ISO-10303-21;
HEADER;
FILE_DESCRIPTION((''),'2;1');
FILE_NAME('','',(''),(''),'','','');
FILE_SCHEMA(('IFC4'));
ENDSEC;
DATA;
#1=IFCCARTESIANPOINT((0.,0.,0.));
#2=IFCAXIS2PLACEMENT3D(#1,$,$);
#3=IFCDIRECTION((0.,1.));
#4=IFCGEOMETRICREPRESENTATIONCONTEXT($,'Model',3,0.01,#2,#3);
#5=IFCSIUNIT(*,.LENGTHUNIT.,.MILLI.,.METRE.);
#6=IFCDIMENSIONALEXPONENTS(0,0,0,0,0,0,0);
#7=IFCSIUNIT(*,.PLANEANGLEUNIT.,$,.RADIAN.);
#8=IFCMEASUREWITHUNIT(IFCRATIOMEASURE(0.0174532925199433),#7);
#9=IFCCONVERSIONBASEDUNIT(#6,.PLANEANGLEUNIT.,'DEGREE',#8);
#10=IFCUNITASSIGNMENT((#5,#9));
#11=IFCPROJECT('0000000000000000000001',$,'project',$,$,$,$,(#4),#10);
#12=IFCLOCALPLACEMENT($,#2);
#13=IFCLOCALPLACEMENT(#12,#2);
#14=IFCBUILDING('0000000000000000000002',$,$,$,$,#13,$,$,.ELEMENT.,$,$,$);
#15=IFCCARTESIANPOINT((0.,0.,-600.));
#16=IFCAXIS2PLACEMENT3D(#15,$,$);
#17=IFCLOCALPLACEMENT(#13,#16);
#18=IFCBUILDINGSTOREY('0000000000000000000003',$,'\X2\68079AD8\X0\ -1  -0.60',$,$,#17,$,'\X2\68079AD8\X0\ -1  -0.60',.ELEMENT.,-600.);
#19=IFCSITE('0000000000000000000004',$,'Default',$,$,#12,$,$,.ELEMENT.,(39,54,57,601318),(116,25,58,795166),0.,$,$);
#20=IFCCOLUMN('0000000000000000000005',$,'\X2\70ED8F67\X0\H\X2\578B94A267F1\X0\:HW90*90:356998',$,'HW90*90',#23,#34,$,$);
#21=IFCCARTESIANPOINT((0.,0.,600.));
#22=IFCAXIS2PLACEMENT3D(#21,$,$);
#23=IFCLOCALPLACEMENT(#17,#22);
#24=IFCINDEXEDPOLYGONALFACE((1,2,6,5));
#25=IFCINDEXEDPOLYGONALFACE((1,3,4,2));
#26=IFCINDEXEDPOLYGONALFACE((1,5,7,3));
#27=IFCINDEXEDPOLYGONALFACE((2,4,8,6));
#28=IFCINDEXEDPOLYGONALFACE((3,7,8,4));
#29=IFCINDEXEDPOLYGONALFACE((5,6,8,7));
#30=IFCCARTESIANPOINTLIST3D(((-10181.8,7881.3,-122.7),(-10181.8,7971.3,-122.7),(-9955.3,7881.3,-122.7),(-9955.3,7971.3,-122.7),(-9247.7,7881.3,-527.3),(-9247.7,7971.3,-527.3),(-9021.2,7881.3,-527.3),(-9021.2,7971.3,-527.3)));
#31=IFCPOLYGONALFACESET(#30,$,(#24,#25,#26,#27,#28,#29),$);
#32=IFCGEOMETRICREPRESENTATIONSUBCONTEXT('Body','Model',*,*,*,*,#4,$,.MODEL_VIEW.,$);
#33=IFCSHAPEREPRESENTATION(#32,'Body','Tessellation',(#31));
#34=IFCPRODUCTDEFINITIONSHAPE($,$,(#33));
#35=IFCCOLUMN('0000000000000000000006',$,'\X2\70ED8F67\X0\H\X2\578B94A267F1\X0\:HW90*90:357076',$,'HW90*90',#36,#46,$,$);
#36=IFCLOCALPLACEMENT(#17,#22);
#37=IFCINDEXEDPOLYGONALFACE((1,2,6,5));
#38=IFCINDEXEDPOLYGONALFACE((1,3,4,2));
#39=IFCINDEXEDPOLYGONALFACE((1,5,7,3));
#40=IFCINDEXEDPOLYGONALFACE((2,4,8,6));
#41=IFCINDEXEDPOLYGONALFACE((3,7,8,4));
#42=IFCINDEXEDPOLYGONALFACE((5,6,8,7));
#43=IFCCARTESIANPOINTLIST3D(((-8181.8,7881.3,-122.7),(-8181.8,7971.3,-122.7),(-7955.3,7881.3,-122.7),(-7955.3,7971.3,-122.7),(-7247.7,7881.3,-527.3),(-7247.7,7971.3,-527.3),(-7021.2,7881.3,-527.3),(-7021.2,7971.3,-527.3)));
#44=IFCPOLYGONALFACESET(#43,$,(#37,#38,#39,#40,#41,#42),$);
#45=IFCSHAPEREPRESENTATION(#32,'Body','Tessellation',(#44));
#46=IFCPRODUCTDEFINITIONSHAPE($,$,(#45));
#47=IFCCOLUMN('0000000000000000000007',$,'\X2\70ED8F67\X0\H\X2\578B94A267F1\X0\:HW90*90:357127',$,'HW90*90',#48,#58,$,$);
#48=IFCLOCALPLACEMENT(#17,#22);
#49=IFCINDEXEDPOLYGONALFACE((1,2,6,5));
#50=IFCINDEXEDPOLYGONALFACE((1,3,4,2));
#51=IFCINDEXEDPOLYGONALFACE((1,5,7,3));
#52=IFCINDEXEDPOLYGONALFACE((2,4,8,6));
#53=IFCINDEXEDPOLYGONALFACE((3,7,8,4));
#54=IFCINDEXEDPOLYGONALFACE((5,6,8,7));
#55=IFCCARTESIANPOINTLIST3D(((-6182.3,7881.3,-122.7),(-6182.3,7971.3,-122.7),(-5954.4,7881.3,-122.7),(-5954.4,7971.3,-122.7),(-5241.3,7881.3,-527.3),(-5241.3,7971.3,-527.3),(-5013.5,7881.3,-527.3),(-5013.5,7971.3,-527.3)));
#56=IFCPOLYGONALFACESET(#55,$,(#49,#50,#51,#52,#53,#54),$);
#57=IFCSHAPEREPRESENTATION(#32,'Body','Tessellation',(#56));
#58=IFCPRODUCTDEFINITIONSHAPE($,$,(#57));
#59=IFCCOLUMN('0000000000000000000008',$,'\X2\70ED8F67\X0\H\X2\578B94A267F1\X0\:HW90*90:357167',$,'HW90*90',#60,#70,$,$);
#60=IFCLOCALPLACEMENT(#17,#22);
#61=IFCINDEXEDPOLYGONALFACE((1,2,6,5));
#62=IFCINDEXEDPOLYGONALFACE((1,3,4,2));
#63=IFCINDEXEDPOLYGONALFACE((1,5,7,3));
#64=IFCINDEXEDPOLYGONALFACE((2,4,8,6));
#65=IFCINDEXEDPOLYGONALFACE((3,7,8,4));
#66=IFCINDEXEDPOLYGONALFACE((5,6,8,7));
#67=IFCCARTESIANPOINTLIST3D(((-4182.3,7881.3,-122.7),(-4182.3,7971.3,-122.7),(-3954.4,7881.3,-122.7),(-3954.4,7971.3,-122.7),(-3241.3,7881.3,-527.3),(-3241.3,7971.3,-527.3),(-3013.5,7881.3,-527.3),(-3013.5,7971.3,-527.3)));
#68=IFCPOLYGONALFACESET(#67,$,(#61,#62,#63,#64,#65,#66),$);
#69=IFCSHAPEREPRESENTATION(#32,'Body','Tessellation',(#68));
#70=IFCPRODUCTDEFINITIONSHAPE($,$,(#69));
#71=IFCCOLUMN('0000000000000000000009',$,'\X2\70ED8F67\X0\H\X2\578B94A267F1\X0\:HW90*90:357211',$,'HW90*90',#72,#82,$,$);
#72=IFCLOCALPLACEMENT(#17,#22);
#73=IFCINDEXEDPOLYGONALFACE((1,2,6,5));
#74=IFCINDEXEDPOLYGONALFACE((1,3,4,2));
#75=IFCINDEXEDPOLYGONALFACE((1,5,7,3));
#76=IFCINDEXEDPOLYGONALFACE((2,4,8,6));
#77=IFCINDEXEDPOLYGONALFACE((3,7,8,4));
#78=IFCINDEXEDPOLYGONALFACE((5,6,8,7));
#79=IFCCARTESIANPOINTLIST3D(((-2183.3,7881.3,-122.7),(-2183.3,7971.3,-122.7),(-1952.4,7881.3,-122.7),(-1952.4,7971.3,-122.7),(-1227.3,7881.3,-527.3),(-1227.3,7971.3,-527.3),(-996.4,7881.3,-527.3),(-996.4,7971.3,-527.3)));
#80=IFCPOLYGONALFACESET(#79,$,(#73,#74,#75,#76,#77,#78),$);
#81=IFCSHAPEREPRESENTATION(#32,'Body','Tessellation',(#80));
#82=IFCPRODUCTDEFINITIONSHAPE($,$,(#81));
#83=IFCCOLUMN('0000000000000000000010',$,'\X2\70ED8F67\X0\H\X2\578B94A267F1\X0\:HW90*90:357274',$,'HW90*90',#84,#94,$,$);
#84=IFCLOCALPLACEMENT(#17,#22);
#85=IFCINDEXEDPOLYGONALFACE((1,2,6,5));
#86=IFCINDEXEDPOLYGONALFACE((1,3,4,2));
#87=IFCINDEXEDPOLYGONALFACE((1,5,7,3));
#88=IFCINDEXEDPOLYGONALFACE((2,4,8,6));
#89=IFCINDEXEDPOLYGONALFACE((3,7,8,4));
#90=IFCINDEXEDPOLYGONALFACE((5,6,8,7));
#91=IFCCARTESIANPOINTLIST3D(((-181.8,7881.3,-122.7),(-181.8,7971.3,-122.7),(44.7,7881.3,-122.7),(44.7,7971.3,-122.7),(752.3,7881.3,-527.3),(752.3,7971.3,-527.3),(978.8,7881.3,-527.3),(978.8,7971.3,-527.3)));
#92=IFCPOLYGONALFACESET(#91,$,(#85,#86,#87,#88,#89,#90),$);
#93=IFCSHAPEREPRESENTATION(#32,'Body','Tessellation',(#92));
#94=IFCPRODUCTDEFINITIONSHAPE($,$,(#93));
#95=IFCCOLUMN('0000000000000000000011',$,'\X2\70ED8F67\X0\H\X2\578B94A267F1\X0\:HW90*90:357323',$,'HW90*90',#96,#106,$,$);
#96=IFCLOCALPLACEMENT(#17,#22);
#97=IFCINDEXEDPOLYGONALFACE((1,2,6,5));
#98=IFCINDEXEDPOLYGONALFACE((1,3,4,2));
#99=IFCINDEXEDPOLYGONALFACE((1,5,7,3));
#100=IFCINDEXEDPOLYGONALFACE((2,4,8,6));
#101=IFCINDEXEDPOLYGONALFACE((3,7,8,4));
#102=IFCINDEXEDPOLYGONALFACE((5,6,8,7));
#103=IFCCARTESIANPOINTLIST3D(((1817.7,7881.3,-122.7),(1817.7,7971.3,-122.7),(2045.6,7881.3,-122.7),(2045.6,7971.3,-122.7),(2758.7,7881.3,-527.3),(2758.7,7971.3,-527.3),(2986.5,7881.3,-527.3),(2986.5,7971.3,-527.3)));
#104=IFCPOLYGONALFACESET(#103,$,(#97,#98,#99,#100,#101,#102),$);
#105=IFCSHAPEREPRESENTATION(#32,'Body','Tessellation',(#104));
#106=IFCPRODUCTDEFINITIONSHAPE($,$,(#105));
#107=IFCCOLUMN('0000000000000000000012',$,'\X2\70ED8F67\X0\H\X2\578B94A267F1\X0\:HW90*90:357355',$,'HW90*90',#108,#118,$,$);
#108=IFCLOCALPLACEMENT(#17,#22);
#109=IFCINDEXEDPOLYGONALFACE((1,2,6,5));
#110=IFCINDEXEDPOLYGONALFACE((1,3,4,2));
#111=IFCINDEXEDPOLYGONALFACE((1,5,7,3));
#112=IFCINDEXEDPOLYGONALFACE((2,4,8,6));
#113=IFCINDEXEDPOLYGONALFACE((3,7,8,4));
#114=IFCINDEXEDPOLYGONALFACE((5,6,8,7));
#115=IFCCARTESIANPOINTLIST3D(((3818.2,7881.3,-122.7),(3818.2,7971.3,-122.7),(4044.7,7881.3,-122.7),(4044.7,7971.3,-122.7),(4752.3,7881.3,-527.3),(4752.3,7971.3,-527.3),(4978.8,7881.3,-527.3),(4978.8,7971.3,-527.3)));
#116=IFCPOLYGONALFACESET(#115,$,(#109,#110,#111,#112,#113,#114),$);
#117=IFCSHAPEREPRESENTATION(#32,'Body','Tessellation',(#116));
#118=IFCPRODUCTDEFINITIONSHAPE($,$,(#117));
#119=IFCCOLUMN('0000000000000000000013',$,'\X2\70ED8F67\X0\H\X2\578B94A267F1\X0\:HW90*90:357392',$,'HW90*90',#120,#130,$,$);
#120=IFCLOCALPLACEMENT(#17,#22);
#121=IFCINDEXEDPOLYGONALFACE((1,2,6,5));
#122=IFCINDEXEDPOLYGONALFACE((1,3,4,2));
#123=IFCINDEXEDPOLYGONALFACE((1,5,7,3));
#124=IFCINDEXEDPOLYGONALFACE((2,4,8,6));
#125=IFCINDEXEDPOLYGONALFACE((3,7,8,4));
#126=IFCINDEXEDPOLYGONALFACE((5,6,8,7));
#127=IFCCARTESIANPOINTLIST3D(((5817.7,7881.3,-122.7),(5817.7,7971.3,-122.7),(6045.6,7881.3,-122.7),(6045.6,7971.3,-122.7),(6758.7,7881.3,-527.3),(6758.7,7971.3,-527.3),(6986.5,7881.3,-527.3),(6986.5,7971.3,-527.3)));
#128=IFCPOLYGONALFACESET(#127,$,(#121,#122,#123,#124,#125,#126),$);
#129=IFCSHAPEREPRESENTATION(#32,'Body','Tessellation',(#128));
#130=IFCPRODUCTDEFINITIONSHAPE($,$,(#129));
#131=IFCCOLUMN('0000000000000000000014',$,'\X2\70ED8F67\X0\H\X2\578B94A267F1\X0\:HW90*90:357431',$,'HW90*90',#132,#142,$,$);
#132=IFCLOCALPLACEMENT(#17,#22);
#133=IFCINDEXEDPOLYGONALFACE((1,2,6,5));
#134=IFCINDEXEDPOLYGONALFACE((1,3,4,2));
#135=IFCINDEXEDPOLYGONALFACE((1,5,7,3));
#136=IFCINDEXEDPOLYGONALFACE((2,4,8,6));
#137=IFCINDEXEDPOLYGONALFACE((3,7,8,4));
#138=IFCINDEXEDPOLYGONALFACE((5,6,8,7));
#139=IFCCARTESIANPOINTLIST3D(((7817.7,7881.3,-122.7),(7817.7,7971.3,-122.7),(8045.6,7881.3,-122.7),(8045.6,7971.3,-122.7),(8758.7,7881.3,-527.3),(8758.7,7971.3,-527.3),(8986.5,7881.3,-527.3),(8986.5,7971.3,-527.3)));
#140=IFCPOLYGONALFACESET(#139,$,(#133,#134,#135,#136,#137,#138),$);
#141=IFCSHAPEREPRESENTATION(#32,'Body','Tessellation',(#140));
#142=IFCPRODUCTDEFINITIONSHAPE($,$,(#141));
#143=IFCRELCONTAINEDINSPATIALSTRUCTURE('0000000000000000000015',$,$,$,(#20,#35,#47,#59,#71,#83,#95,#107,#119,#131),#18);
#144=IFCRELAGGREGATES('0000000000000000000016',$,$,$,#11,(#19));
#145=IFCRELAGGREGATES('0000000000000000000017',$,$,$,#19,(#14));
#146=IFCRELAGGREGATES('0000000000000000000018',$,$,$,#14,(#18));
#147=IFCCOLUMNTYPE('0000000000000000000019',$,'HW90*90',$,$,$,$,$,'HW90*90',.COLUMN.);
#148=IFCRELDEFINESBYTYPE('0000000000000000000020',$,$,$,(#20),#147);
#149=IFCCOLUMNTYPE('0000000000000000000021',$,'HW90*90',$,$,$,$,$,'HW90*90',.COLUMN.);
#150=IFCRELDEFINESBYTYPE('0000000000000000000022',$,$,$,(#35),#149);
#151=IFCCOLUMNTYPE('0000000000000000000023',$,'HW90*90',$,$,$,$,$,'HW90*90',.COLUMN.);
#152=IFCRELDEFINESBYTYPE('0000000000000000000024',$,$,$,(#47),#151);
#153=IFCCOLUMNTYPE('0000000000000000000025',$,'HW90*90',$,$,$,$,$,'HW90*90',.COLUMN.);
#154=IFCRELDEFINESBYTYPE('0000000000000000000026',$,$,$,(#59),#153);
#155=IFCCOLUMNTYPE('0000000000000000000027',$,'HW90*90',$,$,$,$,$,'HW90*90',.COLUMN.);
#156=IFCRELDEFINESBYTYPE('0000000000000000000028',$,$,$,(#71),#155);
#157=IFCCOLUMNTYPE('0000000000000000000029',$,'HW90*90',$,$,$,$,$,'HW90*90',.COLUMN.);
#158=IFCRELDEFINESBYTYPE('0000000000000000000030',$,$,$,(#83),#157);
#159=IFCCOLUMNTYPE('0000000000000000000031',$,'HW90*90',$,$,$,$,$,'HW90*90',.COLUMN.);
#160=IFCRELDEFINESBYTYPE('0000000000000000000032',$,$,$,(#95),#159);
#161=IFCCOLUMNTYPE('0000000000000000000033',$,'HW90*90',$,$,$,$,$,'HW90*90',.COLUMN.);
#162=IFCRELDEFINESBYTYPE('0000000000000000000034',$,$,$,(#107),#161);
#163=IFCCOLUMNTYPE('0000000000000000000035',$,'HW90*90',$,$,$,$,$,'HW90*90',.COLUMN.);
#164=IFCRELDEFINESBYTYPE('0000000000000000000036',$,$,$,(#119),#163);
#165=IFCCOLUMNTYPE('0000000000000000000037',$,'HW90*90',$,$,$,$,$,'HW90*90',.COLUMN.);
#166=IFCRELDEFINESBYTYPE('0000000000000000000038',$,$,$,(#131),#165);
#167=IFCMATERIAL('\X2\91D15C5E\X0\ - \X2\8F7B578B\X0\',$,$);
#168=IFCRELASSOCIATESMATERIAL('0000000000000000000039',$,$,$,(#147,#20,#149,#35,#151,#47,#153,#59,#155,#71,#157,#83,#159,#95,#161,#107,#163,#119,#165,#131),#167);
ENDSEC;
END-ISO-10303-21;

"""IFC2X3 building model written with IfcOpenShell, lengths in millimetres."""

from ifc_helpers import new_model, entity, si_unit, converted_unit, direction, frame, frame_2d, origin, place, context, subcontext, project, spatial, rectangle, extrude, clip, halfspace, source, transform, mapped, material, type_object, type_shapes, element, save


model = new_model("IFC2X3")

# Units and contexts
model_context = context("Model", 3, precision=0.01, world=origin(), true_north=direction((0.0, 1.0)))
body_context = subcontext(model_context, "Body", "Model", "MODEL_VIEW")
ifc_project = project(units=[si_unit("LENGTHUNIT", "METRE", prefix="MILLI"), converted_unit("PLANEANGLEUNIT", "DEGREE", entity("IfcRatioMeasure", 0.0174532925199433), si_unit("PLANEANGLEUNIT", "RADIAN"), dimensions=[0, 0, 0, 0, 0, 0, 0])], contexts=[model_context])

# Site, building, storey
site_placement = place(None, origin())
site = spatial("IfcSite", under=ifc_project, at=site_placement, Name="Default", CompositionType="ELEMENT", RefLatitude=(39, 54, 57, 601318), RefLongitude=(116, 25, 58, 795166), RefElevation=0.0)
building_placement = place(site_placement, origin())
building = spatial("IfcBuilding", under=site, at=building_placement, CompositionType="ELEMENT")
storey_placement = place(building_placement, frame((0.0, 0.0, -600.0)))
storey = spatial("IfcBuildingStorey", under=building, at=storey_placement, Name="标高 -1  -0.60", LongName="标高 -1  -0.60", CompositionType="ELEMENT", Elevation=-600.0)

# Columns
ifc_material = material(Name="金属 - 轻型")
column_type_1 = type_object("IfcColumnType", Name="HW90*90", ElementType="HW90*90", PredefinedType="COLUMN", material=ifc_material)
shared_shape_1 = source(origin(), body_context, "Body", "Clipping", [
    clip(clip(extrude(rectangle(XDim=90.0, YDim=1160.6, at=frame_2d((0.0, 0.0), x_axis=(1.0, 0.0))), frame((-9601.5, 7926.3, -527.3), z_axis=(0.0, 0.0, 1.0), x_axis=(0.0, -1.0, 0.0)), (0.0, 0.0, 1.0), 404.6), halfspace(frame((-10380.3, 7971.3, -36.7), z_axis=(-0.39745, 0.0, -0.917624), x_axis=(0.917624, 0.0, -0.39745)), False)), halfspace(frame((-10344.5, 7881.3, 45.9), z_axis=(0.39745, 0.0, 0.917624), x_axis=(0.917624, 0.0, -0.39745)), False)),
])
type_shapes(column_type_1, [shared_shape_1])
column_1_placement = place(storey_placement, frame((0.0, 0.0, 600.0)))
element("IfcColumn", 1, at=column_1_placement, inside=storey, type_object=column_type_1, material=ifc_material, Name="热轧H型钢柱:HW90*90:356998", ObjectType="HW90*90", context=body_context, shape_type="MappedRepresentation", body=[
    mapped(shared_shape_1, transform((0.0, 0.0, 0.0), scale=1.0)),
])
column_type_2 = type_object("IfcColumnType", Name="HW90*90", ElementType="HW90*90", PredefinedType="COLUMN", material=ifc_material)
shared_shape_2 = source(origin(), body_context, "Body", "Clipping", [
    clip(clip(extrude(rectangle(XDim=90.0, YDim=1160.6, at=frame_2d((0.0, 0.0), x_axis=(1.0, 0.0))), frame((-7601.5, 7926.3, -527.3), z_axis=(0.0, 0.0, 1.0), x_axis=(0.0, -1.0, 0.0)), (0.0, 0.0, 1.0), 404.6), halfspace(frame((-8344.5, 7881.3, 45.9), z_axis=(0.39745, 0.0, 0.917624), x_axis=(0.917624, 0.0, -0.39745)), False)), halfspace(frame((-8380.3, 7971.3, -36.7), z_axis=(-0.39745, 0.0, -0.917624), x_axis=(0.917624, 0.0, -0.39745)), False)),
])
type_shapes(column_type_2, [shared_shape_2])
column_2_placement = place(storey_placement, frame((0.0, 0.0, 600.0)))
element("IfcColumn", 2, at=column_2_placement, inside=storey, type_object=column_type_2, material=ifc_material, Name="热轧H型钢柱:HW90*90:357076", ObjectType="HW90*90", context=body_context, shape_type="MappedRepresentation", body=[
    mapped(shared_shape_2, transform((0.0, 0.0, 0.0), scale=1.0)),
])
column_type_3 = type_object("IfcColumnType", Name="HW90*90", ElementType="HW90*90", PredefinedType="COLUMN", material=ifc_material)
shared_shape_3 = source(origin(), body_context, "Body", "Clipping", [
    clip(clip(extrude(rectangle(XDim=90.0, YDim=1168.8, at=frame_2d((0.0, 0.0), x_axis=(1.0, 0.0))), frame((-5597.9, 7926.3, -527.3), z_axis=(0.0, 0.0, 1.0), x_axis=(0.0, -1.0, 0.0)), (0.0, 0.0, 1.0), 404.6), halfspace(frame((-6346.6, 7881.3, 45.9), z_axis=(0.395028, 0.0, 0.918669), x_axis=(0.918669, 0.0, -0.395028)), False)), halfspace(frame((-6382.1, 7971.3, -36.8), z_axis=(-0.395028, 0.0, -0.918669), x_axis=(0.918669, 0.0, -0.395028)), False)),
])
type_shapes(column_type_3, [shared_shape_3])
column_3_placement = place(storey_placement, frame((0.0, 0.0, 600.0)))
element("IfcColumn", 3, at=column_3_placement, inside=storey, type_object=column_type_3, material=ifc_material, Name="热轧H型钢柱:HW90*90:357127", ObjectType="HW90*90", context=body_context, shape_type="MappedRepresentation", body=[
    mapped(shared_shape_3, transform((0.0, 0.0, 0.0), scale=1.0)),
])
column_type_4 = type_object("IfcColumnType", Name="HW90*90", ElementType="HW90*90", PredefinedType="COLUMN", material=ifc_material)
shared_shape_4 = source(origin(), body_context, "Body", "Clipping", [
    clip(clip(extrude(rectangle(XDim=90.0, YDim=1168.8, at=frame_2d((0.0, 0.0), x_axis=(1.0, 0.0))), frame((-3597.9, 7926.3, -527.3), z_axis=(0.0, 0.0, 1.0), x_axis=(0.0, -1.0, 0.0)), (0.0, 0.0, 1.0), 404.6), halfspace(frame((-4346.6, 7881.3, 45.9), z_axis=(0.395028, 0.0, 0.918669), x_axis=(0.918669, 0.0, -0.395028)), False)), halfspace(frame((-4382.1, 7971.3, -36.8), z_axis=(-0.395028, 0.0, -0.918669), x_axis=(0.918669, 0.0, -0.395028)), False)),
])
type_shapes(column_type_4, [shared_shape_4])
column_4_placement = place(storey_placement, frame((0.0, 0.0, 600.0)))
element("IfcColumn", 4, at=column_4_placement, inside=storey, type_object=column_type_4, material=ifc_material, Name="热轧H型钢柱:HW90*90:357167", ObjectType="HW90*90", context=body_context, shape_type="MappedRepresentation", body=[
    mapped(shared_shape_4, transform((0.0, 0.0, 0.0), scale=1.0)),
])
column_type_5 = type_object("IfcColumnType", Name="HW90*90", ElementType="HW90*90", PredefinedType="COLUMN", material=ifc_material)
shared_shape_5 = source(origin(), body_context, "Body", "Clipping", [
    clip(clip(extrude(rectangle(XDim=90.0, YDim=1187.0, at=frame_2d((0.0, 0.0), x_axis=(1.0, 0.0))), frame((-1589.8, 7926.3, -527.3), z_axis=(0.0, 0.0, 1.0), x_axis=(0.0, -1.0, 0.0)), (0.0, 0.0, 1.0), 404.6), halfspace(frame((-2386.2, 7971.3, -36.9), z_axis=(-0.389735, 0.0, -0.920927), x_axis=(0.920927, 0.0, -0.389735)), False)), halfspace(frame((-2351.1, 7881.3, 46.0), z_axis=(0.389735, 0.0, 0.920927), x_axis=(0.920927, 0.0, -0.389735)), False)),
])
type_shapes(column_type_5, [shared_shape_5])
column_5_placement = place(storey_placement, frame((0.0, 0.0, 600.0)))
element("IfcColumn", 5, at=column_5_placement, inside=storey, type_object=column_type_5, material=ifc_material, Name="热轧H型钢柱:HW90*90:357211", ObjectType="HW90*90", context=body_context, shape_type="MappedRepresentation", body=[
    mapped(shared_shape_5, transform((0.0, 0.0, 0.0), scale=1.0)),
])
column_type_6 = type_object("IfcColumnType", Name="HW90*90", ElementType="HW90*90", PredefinedType="COLUMN", material=ifc_material)
shared_shape_6 = source(origin(), body_context, "Body", "Clipping", [
    clip(clip(extrude(rectangle(XDim=90.0, YDim=1160.6, at=frame_2d((0.0, 0.0), x_axis=(1.0, 0.0))), frame((398.5, 7926.3, -527.3), z_axis=(0.0, 0.0, 1.0), x_axis=(0.0, -1.0, 0.0)), (0.0, 0.0, 1.0), 404.6), halfspace(frame((-344.5, 7881.3, 45.9), z_axis=(0.39745, 0.0, 0.917624), x_axis=(0.917624, 0.0, -0.39745)), False)), halfspace(frame((-380.3, 7971.3, -36.7), z_axis=(-0.39745, 0.0, -0.917624), x_axis=(0.917624, 0.0, -0.39745)), False)),
])
type_shapes(column_type_6, [shared_shape_6])
column_6_placement = place(storey_placement, frame((0.0, 0.0, 600.0)))
element("IfcColumn", 6, at=column_6_placement, inside=storey, type_object=column_type_6, material=ifc_material, Name="热轧H型钢柱:HW90*90:357274", ObjectType="HW90*90", context=body_context, shape_type="MappedRepresentation", body=[
    mapped(shared_shape_6, transform((0.0, 0.0, 0.0), scale=1.0)),
])
column_type_7 = type_object("IfcColumnType", Name="HW90*90", ElementType="HW90*90", PredefinedType="COLUMN", material=ifc_material)
shared_shape_7 = source(origin(), body_context, "Body", "Clipping", [
    clip(clip(extrude(rectangle(XDim=90.0, YDim=1168.8, at=frame_2d((0.0, 0.0), x_axis=(1.0, 0.0))), frame((2402.1, 7926.3, -527.3), z_axis=(0.0, 0.0, 1.0), x_axis=(0.0, -1.0, 0.0)), (0.0, 0.0, 1.0), 404.6), halfspace(frame((1617.9, 7971.3, -36.8), z_axis=(-0.395028, 0.0, -0.918669), x_axis=(0.918669, 0.0, -0.395028)), False)), halfspace(frame((1653.4, 7881.3, 45.9), z_axis=(0.395028, 0.0, 0.918669), x_axis=(0.918669, 0.0, -0.395028)), False)),
])
type_shapes(column_type_7, [shared_shape_7])
column_7_placement = place(storey_placement, frame((0.0, 0.0, 600.0)))
element("IfcColumn", 7, at=column_7_placement, inside=storey, type_object=column_type_7, material=ifc_material, Name="热轧H型钢柱:HW90*90:357323", ObjectType="HW90*90", context=body_context, shape_type="MappedRepresentation", body=[
    mapped(shared_shape_7, transform((0.0, 0.0, 0.0), scale=1.0)),
])
column_type_8 = type_object("IfcColumnType", Name="HW90*90", ElementType="HW90*90", PredefinedType="COLUMN", material=ifc_material)
shared_shape_8 = source(origin(), body_context, "Body", "Clipping", [
    clip(clip(extrude(rectangle(XDim=90.0, YDim=1160.6, at=frame_2d((0.0, 0.0), x_axis=(1.0, 0.0))), frame((4398.5, 7926.3, -527.3), z_axis=(0.0, 0.0, 1.0), x_axis=(0.0, -1.0, 0.0)), (0.0, 0.0, 1.0), 404.6), halfspace(frame((3655.5, 7881.3, 45.9), z_axis=(0.39745, 0.0, 0.917624), x_axis=(0.917624, 0.0, -0.39745)), False)), halfspace(frame((3619.7, 7971.3, -36.7), z_axis=(-0.39745, 0.0, -0.917624), x_axis=(0.917624, 0.0, -0.39745)), False)),
])
type_shapes(column_type_8, [shared_shape_8])
column_8_placement = place(storey_placement, frame((0.0, 0.0, 600.0)))
element("IfcColumn", 8, at=column_8_placement, inside=storey, type_object=column_type_8, material=ifc_material, Name="热轧H型钢柱:HW90*90:357355", ObjectType="HW90*90", context=body_context, shape_type="MappedRepresentation", body=[
    mapped(shared_shape_8, transform((0.0, 0.0, 0.0), scale=1.0)),
])
column_type_9 = type_object("IfcColumnType", Name="HW90*90", ElementType="HW90*90", PredefinedType="COLUMN", material=ifc_material)
shared_shape_9 = source(origin(), body_context, "Body", "Clipping", [
    clip(clip(extrude(rectangle(XDim=90.0, YDim=1168.8, at=frame_2d((0.0, 0.0), x_axis=(1.0, 0.0))), frame((6402.1, 7926.3, -527.3), z_axis=(0.0, 0.0, 1.0), x_axis=(0.0, -1.0, 0.0)), (0.0, 0.0, 1.0), 404.6), halfspace(frame((5653.4, 7881.3, 45.9), z_axis=(0.395028, 0.0, 0.918669), x_axis=(0.918669, 0.0, -0.395028)), False)), halfspace(frame((5617.9, 7971.3, -36.8), z_axis=(-0.395028, 0.0, -0.918669), x_axis=(0.918669, 0.0, -0.395028)), False)),
])
type_shapes(column_type_9, [shared_shape_9])
column_9_placement = place(storey_placement, frame((0.0, 0.0, 600.0)))
element("IfcColumn", 9, at=column_9_placement, inside=storey, type_object=column_type_9, material=ifc_material, Name="热轧H型钢柱:HW90*90:357392", ObjectType="HW90*90", context=body_context, shape_type="MappedRepresentation", body=[
    mapped(shared_shape_9, transform((0.0, 0.0, 0.0), scale=1.0)),
])
column_type_10 = type_object("IfcColumnType", Name="HW90*90", ElementType="HW90*90", PredefinedType="COLUMN", material=ifc_material)
shared_shape_10 = source(origin(), body_context, "Body", "Clipping", [
    clip(clip(extrude(rectangle(XDim=90.0, YDim=1168.8, at=frame_2d((0.0, 0.0), x_axis=(1.0, 0.0))), frame((8402.1, 7926.3, -527.3), z_axis=(0.0, 0.0, 1.0), x_axis=(0.0, -1.0, 0.0)), (0.0, 0.0, 1.0), 404.6), halfspace(frame((7617.9, 7971.3, -36.8), z_axis=(-0.395028, 0.0, -0.918669), x_axis=(0.918669, 0.0, -0.395028)), False)), halfspace(frame((7653.4, 7881.3, 45.9), z_axis=(0.395028, 0.0, 0.918669), x_axis=(0.918669, 0.0, -0.395028)), False)),
])
type_shapes(column_type_10, [shared_shape_10])
column_10_placement = place(storey_placement, frame((0.0, 0.0, 600.0)))
element("IfcColumn", 10, at=column_10_placement, inside=storey, type_object=column_type_10, material=ifc_material, Name="热轧H型钢柱:HW90*90:357431", ObjectType="HW90*90", context=body_context, shape_type="MappedRepresentation", body=[
    mapped(shared_shape_10, transform((0.0, 0.0, 0.0), scale=1.0)),
])

save(model, "model.ifc")
